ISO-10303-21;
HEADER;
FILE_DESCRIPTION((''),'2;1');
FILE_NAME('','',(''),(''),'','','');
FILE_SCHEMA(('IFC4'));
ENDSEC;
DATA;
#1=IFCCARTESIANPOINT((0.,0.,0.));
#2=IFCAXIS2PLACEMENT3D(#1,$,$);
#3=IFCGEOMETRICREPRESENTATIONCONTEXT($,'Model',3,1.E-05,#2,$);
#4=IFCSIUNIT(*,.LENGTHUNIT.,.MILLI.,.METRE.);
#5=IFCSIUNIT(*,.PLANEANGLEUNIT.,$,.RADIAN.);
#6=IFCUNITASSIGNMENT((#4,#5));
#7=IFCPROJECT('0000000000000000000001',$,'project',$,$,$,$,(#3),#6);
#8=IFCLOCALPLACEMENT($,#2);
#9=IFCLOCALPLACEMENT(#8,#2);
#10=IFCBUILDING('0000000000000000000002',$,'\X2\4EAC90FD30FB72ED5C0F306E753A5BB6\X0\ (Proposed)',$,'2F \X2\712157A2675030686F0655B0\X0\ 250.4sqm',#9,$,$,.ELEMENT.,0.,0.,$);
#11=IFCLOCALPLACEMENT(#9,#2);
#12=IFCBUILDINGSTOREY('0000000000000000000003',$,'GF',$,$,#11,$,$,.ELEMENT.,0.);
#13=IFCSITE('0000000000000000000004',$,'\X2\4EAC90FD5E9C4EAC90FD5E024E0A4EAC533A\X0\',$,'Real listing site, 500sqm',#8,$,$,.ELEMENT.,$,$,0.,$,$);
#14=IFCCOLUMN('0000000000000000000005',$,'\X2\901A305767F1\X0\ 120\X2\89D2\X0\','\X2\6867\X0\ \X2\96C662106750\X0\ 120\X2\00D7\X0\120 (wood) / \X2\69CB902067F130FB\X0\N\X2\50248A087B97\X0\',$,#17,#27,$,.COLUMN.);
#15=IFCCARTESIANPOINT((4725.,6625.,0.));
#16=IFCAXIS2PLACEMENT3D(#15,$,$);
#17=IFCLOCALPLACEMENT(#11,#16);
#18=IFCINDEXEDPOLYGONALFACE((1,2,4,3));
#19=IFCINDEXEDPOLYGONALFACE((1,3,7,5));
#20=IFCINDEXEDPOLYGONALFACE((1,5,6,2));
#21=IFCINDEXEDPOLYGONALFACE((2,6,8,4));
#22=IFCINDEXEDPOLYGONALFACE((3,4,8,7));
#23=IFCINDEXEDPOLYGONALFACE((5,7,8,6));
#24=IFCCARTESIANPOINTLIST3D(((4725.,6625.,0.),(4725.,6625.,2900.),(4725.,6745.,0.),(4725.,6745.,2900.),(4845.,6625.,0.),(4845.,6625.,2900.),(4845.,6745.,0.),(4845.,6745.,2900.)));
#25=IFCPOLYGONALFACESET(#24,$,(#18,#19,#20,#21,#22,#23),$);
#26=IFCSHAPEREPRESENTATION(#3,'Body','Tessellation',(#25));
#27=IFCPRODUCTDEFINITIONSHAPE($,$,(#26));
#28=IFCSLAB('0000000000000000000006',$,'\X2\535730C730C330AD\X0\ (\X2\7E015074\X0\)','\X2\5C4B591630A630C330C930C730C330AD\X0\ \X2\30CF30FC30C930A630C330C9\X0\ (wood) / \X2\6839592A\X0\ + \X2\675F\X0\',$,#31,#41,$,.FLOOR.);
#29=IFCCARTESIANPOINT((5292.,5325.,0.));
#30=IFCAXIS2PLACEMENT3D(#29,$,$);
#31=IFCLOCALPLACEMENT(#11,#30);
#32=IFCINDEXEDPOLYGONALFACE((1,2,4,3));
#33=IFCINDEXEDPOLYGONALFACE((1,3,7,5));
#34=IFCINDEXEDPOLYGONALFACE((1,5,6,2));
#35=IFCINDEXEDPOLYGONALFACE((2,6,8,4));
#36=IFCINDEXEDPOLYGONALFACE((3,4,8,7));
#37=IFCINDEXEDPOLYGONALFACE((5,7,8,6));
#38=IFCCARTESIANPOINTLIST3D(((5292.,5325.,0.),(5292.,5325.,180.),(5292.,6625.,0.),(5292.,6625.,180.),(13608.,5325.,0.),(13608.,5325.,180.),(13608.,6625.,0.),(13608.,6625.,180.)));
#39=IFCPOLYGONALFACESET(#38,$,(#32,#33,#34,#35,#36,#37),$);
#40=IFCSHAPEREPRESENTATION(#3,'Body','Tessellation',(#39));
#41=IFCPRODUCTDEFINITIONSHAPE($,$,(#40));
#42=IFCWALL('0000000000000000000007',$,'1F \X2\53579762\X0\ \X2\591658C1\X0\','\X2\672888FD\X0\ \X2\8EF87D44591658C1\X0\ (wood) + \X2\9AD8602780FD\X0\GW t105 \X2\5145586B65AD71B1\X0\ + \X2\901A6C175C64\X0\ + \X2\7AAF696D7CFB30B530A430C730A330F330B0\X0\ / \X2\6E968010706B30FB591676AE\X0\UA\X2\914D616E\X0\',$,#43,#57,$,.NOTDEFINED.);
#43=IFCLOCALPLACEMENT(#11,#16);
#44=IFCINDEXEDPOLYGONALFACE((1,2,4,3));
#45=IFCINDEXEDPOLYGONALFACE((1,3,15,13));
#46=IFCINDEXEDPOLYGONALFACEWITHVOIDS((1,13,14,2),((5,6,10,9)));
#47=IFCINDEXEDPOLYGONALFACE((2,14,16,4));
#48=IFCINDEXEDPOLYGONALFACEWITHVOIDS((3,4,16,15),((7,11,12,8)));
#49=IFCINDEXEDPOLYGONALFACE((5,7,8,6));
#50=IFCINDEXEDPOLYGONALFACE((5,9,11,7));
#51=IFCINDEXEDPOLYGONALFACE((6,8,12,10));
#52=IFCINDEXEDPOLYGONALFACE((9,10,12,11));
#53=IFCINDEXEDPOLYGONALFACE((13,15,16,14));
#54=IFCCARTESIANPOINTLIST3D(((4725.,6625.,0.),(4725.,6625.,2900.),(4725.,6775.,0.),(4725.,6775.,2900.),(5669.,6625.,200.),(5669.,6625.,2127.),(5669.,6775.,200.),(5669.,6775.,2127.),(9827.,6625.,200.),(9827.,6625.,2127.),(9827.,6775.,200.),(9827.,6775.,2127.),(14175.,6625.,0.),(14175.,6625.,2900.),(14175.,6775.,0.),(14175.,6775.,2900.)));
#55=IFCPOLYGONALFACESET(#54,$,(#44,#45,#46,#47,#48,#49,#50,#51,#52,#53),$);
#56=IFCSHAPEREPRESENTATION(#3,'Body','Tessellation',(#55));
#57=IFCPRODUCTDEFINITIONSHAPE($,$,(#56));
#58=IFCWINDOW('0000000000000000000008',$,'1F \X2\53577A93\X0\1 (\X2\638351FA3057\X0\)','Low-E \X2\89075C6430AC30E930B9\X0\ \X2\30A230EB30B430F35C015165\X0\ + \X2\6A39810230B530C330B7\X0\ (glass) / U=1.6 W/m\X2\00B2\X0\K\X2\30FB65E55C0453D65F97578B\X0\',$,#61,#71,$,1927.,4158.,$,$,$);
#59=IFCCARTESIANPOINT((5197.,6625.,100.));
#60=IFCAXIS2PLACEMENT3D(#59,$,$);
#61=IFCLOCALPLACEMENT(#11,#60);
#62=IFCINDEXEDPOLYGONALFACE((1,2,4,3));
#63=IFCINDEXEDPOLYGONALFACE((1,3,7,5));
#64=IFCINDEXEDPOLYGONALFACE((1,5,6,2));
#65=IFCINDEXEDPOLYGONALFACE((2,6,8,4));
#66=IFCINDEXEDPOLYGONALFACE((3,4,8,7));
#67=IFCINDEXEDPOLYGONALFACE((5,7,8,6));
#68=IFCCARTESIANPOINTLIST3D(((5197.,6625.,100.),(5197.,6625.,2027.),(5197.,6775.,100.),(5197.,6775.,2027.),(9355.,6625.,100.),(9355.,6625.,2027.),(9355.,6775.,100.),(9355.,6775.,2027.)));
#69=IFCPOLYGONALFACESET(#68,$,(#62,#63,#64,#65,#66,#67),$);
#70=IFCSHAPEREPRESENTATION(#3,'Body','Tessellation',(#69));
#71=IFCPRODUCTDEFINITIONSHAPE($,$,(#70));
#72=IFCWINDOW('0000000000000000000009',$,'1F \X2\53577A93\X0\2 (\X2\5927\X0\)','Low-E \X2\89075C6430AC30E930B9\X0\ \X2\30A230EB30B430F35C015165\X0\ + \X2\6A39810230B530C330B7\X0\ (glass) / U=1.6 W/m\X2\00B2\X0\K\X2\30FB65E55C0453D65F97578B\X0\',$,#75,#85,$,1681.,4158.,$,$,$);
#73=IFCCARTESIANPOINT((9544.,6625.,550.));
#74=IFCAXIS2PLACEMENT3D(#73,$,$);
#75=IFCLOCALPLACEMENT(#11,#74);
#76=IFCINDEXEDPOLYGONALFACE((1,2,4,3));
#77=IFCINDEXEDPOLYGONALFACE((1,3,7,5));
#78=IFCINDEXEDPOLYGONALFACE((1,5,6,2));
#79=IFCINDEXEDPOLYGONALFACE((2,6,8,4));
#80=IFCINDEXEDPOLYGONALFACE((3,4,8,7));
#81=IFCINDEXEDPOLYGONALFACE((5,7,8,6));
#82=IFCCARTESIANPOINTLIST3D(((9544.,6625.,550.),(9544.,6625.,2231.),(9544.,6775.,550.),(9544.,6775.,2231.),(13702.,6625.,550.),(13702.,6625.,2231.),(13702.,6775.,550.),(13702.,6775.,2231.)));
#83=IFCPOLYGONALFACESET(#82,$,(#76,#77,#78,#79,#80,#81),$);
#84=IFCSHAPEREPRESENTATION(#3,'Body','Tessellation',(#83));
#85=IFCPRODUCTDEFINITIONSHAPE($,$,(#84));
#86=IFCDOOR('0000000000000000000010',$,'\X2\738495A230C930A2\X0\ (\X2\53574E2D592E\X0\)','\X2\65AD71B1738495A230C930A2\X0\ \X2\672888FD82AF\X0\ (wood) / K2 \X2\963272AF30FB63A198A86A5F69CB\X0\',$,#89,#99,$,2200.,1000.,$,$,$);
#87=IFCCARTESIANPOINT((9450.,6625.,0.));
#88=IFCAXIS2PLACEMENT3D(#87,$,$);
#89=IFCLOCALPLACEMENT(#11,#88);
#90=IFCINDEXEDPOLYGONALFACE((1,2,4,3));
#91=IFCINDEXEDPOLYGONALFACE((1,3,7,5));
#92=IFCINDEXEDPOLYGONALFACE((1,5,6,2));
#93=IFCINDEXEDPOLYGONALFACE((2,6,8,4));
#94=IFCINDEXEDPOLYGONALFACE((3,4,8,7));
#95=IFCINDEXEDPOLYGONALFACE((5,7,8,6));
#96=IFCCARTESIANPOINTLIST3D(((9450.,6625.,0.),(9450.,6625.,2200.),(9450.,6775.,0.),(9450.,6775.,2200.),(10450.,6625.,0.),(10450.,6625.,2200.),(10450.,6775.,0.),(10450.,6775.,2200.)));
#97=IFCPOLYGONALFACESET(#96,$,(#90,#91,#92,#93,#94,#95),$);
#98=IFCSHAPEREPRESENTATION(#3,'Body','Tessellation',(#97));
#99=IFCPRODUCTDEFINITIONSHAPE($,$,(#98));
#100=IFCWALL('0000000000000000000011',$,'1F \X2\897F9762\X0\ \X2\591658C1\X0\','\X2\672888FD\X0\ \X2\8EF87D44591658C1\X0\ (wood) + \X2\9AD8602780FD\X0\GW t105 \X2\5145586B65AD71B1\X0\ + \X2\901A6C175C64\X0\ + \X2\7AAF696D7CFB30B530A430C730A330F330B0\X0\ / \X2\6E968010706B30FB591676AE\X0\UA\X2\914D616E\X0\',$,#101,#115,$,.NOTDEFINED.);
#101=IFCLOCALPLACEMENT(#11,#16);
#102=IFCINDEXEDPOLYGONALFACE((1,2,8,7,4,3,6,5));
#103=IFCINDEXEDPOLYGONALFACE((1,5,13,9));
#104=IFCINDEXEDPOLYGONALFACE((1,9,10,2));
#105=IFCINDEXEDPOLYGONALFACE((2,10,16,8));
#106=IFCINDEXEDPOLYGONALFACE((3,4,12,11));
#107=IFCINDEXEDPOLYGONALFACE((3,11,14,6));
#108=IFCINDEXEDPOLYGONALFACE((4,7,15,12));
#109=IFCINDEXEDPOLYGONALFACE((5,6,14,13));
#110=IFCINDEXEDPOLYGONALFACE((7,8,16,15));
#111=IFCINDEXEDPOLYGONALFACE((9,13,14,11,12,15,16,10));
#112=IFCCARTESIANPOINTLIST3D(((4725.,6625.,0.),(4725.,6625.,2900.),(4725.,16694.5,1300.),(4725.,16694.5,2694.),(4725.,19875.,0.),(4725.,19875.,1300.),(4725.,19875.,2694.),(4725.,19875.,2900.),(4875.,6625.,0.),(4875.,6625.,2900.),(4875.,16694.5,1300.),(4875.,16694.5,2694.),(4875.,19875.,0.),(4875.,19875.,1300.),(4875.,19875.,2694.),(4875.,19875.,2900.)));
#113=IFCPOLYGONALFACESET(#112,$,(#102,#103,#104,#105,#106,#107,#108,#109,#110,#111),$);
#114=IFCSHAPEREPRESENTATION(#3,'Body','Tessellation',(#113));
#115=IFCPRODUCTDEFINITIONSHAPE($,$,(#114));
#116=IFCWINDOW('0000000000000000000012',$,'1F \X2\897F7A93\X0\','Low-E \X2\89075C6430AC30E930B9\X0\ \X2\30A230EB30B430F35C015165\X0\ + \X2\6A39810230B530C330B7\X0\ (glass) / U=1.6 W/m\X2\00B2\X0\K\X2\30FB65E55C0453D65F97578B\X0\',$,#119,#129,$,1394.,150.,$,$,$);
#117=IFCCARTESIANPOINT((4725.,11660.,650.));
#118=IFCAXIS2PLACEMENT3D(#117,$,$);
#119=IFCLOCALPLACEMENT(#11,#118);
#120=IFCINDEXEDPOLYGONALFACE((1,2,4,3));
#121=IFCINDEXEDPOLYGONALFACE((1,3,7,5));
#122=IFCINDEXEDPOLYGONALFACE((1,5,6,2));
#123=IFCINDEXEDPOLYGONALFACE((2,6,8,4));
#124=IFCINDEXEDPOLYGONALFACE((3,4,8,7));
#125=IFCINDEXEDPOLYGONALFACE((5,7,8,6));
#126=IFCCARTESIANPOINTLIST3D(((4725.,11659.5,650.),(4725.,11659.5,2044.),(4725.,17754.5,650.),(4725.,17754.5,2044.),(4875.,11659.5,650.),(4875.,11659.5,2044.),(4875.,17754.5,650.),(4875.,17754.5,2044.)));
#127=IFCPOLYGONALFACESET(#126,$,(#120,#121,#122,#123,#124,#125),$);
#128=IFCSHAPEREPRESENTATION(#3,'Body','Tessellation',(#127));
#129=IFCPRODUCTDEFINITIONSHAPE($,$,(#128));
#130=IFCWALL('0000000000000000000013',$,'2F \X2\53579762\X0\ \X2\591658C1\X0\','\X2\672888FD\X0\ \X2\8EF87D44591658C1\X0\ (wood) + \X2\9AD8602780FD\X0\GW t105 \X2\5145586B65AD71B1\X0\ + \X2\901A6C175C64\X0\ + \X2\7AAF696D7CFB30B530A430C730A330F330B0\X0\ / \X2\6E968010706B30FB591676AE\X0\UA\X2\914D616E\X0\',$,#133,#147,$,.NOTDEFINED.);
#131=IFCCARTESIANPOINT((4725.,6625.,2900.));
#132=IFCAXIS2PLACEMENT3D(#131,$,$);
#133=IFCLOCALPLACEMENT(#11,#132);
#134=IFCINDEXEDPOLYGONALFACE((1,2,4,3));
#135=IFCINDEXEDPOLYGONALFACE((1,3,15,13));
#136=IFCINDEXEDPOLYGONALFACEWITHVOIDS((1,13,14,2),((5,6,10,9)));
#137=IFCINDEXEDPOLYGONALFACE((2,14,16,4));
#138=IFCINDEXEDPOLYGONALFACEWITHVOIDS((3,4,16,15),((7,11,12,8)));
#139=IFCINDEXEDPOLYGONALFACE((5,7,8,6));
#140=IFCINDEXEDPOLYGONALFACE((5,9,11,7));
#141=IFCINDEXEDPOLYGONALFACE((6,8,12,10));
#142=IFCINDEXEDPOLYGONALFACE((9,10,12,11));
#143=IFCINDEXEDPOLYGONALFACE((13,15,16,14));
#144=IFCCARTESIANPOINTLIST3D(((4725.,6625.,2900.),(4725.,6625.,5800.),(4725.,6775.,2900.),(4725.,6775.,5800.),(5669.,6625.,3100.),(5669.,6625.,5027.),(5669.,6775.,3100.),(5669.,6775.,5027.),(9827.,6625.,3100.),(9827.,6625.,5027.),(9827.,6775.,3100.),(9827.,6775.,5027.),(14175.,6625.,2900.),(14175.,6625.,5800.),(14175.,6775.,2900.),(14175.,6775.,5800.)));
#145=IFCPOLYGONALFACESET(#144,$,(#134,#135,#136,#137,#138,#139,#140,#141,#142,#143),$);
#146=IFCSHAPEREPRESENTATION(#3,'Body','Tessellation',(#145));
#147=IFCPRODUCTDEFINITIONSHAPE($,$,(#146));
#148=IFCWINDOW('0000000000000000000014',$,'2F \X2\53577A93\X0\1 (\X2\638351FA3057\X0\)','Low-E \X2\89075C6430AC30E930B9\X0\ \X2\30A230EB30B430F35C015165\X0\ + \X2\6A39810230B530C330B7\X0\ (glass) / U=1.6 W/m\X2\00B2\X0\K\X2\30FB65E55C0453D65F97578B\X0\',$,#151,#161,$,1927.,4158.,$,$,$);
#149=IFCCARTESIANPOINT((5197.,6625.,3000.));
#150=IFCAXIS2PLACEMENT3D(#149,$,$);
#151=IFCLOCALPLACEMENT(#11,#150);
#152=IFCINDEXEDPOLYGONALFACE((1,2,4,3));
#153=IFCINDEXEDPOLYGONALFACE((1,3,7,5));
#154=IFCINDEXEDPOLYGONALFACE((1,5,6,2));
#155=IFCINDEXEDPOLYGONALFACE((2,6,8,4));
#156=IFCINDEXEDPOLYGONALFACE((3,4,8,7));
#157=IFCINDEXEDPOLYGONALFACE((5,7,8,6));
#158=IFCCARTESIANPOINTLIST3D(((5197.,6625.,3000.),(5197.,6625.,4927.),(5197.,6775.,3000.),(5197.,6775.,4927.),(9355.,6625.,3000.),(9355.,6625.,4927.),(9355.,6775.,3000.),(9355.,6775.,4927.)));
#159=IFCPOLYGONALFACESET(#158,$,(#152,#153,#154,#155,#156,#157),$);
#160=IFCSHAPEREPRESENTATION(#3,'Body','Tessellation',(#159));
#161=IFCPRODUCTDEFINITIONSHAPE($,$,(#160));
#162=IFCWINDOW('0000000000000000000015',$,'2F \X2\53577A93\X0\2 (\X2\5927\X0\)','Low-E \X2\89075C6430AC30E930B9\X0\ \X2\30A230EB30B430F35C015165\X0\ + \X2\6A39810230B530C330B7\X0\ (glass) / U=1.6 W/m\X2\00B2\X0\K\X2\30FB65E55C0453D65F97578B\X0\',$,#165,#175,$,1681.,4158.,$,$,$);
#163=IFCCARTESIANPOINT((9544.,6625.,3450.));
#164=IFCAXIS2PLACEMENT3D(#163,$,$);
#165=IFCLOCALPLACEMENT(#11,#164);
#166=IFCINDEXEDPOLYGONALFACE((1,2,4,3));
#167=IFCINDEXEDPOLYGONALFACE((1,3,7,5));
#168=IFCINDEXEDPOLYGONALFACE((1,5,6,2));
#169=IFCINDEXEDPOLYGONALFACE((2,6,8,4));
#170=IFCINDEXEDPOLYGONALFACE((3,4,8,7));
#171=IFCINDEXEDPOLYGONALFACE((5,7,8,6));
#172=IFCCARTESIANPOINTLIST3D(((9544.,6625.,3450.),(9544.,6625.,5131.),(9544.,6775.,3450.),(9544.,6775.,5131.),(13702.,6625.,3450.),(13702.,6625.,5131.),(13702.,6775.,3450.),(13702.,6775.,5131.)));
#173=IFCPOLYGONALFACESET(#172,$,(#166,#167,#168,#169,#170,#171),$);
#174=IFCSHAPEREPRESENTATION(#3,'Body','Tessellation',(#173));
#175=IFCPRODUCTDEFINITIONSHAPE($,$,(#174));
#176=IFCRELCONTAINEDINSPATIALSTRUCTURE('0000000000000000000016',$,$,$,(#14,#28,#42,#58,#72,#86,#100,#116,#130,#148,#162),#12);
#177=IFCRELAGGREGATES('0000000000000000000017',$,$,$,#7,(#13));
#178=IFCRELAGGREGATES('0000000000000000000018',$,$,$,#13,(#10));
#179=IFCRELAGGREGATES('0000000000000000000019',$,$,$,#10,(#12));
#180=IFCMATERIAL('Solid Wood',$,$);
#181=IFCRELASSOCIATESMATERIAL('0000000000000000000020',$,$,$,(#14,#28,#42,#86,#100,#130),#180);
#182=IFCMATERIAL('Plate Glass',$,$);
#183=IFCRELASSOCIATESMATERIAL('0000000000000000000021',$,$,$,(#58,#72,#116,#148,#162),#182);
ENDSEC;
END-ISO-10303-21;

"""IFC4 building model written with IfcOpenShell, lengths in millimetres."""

from ifc_helpers import new_model, si_unit, frame, frame_2d, origin, place, context, project, spatial, rectangle, extrude, material, element, fill, save


model = new_model("IFC4")

# Units and contexts
model_context = context("Model", 3, precision=1e-05, world=origin())
ifc_project = project(units=[si_unit("LENGTHUNIT", "METRE", prefix="MILLI"), si_unit("PLANEANGLEUNIT", "RADIAN")], contexts=[model_context])

# Site, building, storey
site_placement = place(None, origin())
site = spatial("IfcSite", under=ifc_project, at=site_placement, Name="京都府京都市上京区", ObjectType="Real listing site, 500sqm", CompositionType="ELEMENT", RefElevation=0.0)
building_placement = place(site_placement, origin())
building = spatial("IfcBuilding", under=site, at=building_placement, Name="京都・狭小の町家 (Proposed)", ObjectType="2F 無垢材と漆喰 250.4sqm", CompositionType="ELEMENT", ElevationOfRefHeight=0.0, ElevationOfTerrain=0.0)
storey_placement = place(building_placement, origin())
storey = spatial("IfcBuildingStorey", under=building, at=storey_placement, Name="GF", CompositionType="ELEMENT", Elevation=0.0)

# Column
ifc_material_1 = material(Name="Solid Wood")
column_placement = place(storey_placement, frame((4725.0, 6625.0, 0.0)))
element("IfcColumn", 1, at=column_placement, inside=storey, material=ifc_material_1, Name="通し柱 120角", Description="桧 集成材 120×120 (wood) / 構造柱・N値計算", PredefinedType="COLUMN", context=model_context, shape_type="SweptSolid", body=[
    extrude(rectangle(XDim=120.0, YDim=120.0, at=frame_2d((60.0, 60.0))), frame((4725.0, 6625.0, 0.0)), (0.0, 0.0, 1.0), 2900.0),
])

# Slab
slab_1_placement = place(storey_placement, frame((5292.0, 5325.0, 0.0)))
element("IfcSlab", 2, at=slab_1_placement, inside=storey, material=ifc_material_1, Name="南デッキ (縁側)", Description="屋外ウッドデッキ ハードウッド (wood) / 根太 + 束", PredefinedType="FLOOR", context=model_context, shape_type="SweptSolid", body=[
    extrude(rectangle(XDim=8316.0, YDim=1300.0, at=frame_2d((4158.0, 650.0))), frame((5292.0, 5325.0, 0.0)), (0.0, 0.0, 1.0), 180.0),
])

# Wall, openings, windows, door
wall_1_placement = place(storey_placement, frame((4725.0, 6625.0, 0.0)))
wall_1 = element("IfcWall", 3, at=wall_1_placement, inside=storey, material=ifc_material_1, Name="1F 南面 外壁", Description="木製 軸組外壁 (wood) + 高性能GW t105 充填断熱 + 通気層 + 窯業系サイディング / 準耐火・外皮UA配慮", PredefinedType="NOTDEFINED", context=model_context, shape_type="SweptSolid", body=[
    extrude(rectangle(XDim=9450.0, YDim=150.0, at=frame_2d((4725.0, 75.0))), frame((4725.0, 6625.0, 0.0)), (0.0, 0.0, 1.0), 2900.0),
])
opening_1_placement = place(storey_placement, frame((5197.0, 6625.0, 100.0)))
opening_1 = element("IfcOpeningElement", 4, at=opening_1_placement, cuts=wall_1, PredefinedType="NOTDEFINED", context=model_context, shape_type="SweptSolid", body=[
    extrude(rectangle(XDim=4158.0, YDim=150.0, at=frame_2d((2079.0, 75.0))), frame((5197.0, 6625.0, 100.0)), (0.0, 0.0, 1.0), 1927.0),
])
opening_2_placement = place(storey_placement, frame((9544.0, 6625.0, 550.0)))
opening_2 = element("IfcOpeningElement", 5, at=opening_2_placement, cuts=wall_1, PredefinedType="NOTDEFINED", context=model_context, shape_type="SweptSolid", body=[
    extrude(rectangle(XDim=4158.0, YDim=150.0, at=frame_2d((2079.0, 75.0))), frame((9544.0, 6625.0, 550.0)), (0.0, 0.0, 1.0), 1681.0),
])
opening_3_placement = place(storey_placement, frame((9450.0, 6625.0, 0.0)))
opening_3 = element("IfcOpeningElement", 6, at=opening_3_placement, cuts=wall_1, PredefinedType="NOTDEFINED", context=model_context, shape_type="SweptSolid", body=[
    extrude(rectangle(XDim=1000.0, YDim=150.0, at=frame_2d((500.0, 75.0))), frame((9450.0, 6625.0, 0.0)), (0.0, 0.0, 1.0), 2200.0),
])
ifc_material_2 = material(Name="Plate Glass")
window_1_placement = place(storey_placement, frame((5197.0, 6625.0, 100.0)))
window_1 = element("IfcWindow", 7, at=window_1_placement, inside=storey, material=ifc_material_2, Name="1F 南窓1 (掃出し)", Description="Low-E 複層ガラス アルゴン封入 + 樹脂サッシ (glass) / U=1.6 W/m²K・日射取得型", OverallHeight=1927.0, OverallWidth=4158.0, context=model_context, shape_type="SweptSolid", body=[
    extrude(rectangle(XDim=4158.0, YDim=150.0, at=frame_2d((2079.0, 75.0))), frame((5197.0, 6625.0, 100.0)), (0.0, 0.0, 1.0), 1927.0),
])
fill(opening_1, window_1)
window_2_placement = place(storey_placement, frame((9544.0, 6625.0, 550.0)))
window_2 = element("IfcWindow", 8, at=window_2_placement, inside=storey, material=ifc_material_2, Name="1F 南窓2 (大)", Description="Low-E 複層ガラス アルゴン封入 + 樹脂サッシ (glass) / U=1.6 W/m²K・日射取得型", OverallHeight=1681.0, OverallWidth=4158.0, context=model_context, shape_type="SweptSolid", body=[
    extrude(rectangle(XDim=4158.0, YDim=150.0, at=frame_2d((2079.0, 75.0))), frame((9544.0, 6625.0, 550.0)), (0.0, 0.0, 1.0), 1681.0),
])
fill(opening_2, window_2)
door_placement = place(storey_placement, frame((9450.0, 6625.0, 0.0)))
door = element("IfcDoor", 9, at=door_placement, inside=storey, material=ifc_material_1, Name="玄関ドア (南中央)", Description="断熱玄関ドア 木製芯 (wood) / K2 防犯・採風機構", OverallHeight=2200.0, OverallWidth=1000.0, context=model_context, shape_type="SweptSolid", body=[
    extrude(rectangle(XDim=1000.0, YDim=150.0, at=frame_2d((500.0, 75.0))), frame((9450.0, 6625.0, 0.0)), (0.0, 0.0, 1.0), 2200.0),
])
fill(opening_3, door)

# Wall, opening, window
wall_2_placement = place(storey_placement, frame((4725.0, 6625.0, 0.0)))
wall_2 = element("IfcWall", 10, at=wall_2_placement, inside=storey, material=ifc_material_1, Name="1F 西面 外壁", Description="木製 軸組外壁 (wood) + 高性能GW t105 充填断熱 + 通気層 + 窯業系サイディング / 準耐火・外皮UA配慮", PredefinedType="NOTDEFINED", context=model_context, shape_type="SweptSolid", body=[
    extrude(rectangle(XDim=150.0, YDim=13250.0, at=frame_2d((75.0, 6625.0))), frame((4725.0, 6625.0, 0.0)), (0.0, 0.0, 1.0), 2900.0),
])
opening_4_placement = place(storey_placement, frame((4725.0, 11660.0, 650.0)))
opening_4 = element("IfcOpeningElement", 11, at=opening_4_placement, cuts=wall_2, PredefinedType="NOTDEFINED", context=model_context, shape_type="SweptSolid", body=[
    extrude(rectangle(XDim=150.0, YDim=6095.0, at=frame_2d((75.0, 3047.0))), frame((4725.0, 11660.0, 650.0)), (0.0, 0.0, 1.0), 1394.0),
])
window_3_placement = place(storey_placement, frame((4725.0, 11660.0, 650.0)))
window_3 = element("IfcWindow", 12, at=window_3_placement, inside=storey, material=ifc_material_2, Name="1F 西窓", Description="Low-E 複層ガラス アルゴン封入 + 樹脂サッシ (glass) / U=1.6 W/m²K・日射取得型", OverallHeight=1394.0, OverallWidth=150.0, context=model_context, shape_type="SweptSolid", body=[
    extrude(rectangle(XDim=150.0, YDim=6095.0, at=frame_2d((75.0, 3047.0))), frame((4725.0, 11660.0, 650.0)), (0.0, 0.0, 1.0), 1394.0),
])
fill(opening_4, window_3)

# Wall, openings, windows
wall_3_placement = place(storey_placement, frame((4725.0, 6625.0, 2900.0)))
wall_3 = element("IfcWall", 13, at=wall_3_placement, inside=storey, material=ifc_material_1, Name="2F 南面 外壁", Description="木製 軸組外壁 (wood) + 高性能GW t105 充填断熱 + 通気層 + 窯業系サイディング / 準耐火・外皮UA配慮", PredefinedType="NOTDEFINED", context=model_context, shape_type="SweptSolid", body=[
    extrude(rectangle(XDim=9450.0, YDim=150.0, at=frame_2d((4725.0, 75.0))), frame((4725.0, 6625.0, 2900.0)), (0.0, 0.0, 1.0), 2900.0),
])
opening_5_placement = place(storey_placement, frame((5197.0, 6625.0, 3000.0)))
opening_5 = element("IfcOpeningElement", 14, at=opening_5_placement, cuts=wall_3, PredefinedType="NOTDEFINED", context=model_context, shape_type="SweptSolid", body=[
    extrude(rectangle(XDim=4158.0, YDim=150.0, at=frame_2d((2079.0, 75.0))), frame((5197.0, 6625.0, 3000.0)), (0.0, 0.0, 1.0), 1927.0),
])
opening_6_placement = place(storey_placement, frame((9544.0, 6625.0, 3450.0)))
opening_6 = element("IfcOpeningElement", 15, at=opening_6_placement, cuts=wall_3, PredefinedType="NOTDEFINED", context=model_context, shape_type="SweptSolid", body=[
    extrude(rectangle(XDim=4158.0, YDim=150.0, at=frame_2d((2079.0, 75.0))), frame((9544.0, 6625.0, 3450.0)), (0.0, 0.0, 1.0), 1681.0),
])
window_4_placement = place(storey_placement, frame((5197.0, 6625.0, 3000.0)))
window_4 = element("IfcWindow", 16, at=window_4_placement, inside=storey, material=ifc_material_2, Name="2F 南窓1 (掃出し)", Description="Low-E 複層ガラス アルゴン封入 + 樹脂サッシ (glass) / U=1.6 W/m²K・日射取得型", OverallHeight=1927.0, OverallWidth=4158.0, context=model_context, shape_type="SweptSolid", body=[
    extrude(rectangle(XDim=4158.0, YDim=150.0, at=frame_2d((2079.0, 75.0))), frame((5197.0, 6625.0, 3000.0)), (0.0, 0.0, 1.0), 1927.0),
])
fill(opening_5, window_4)
window_5_placement = place(storey_placement, frame((9544.0, 6625.0, 3450.0)))
window_5 = element("IfcWindow", 17, at=window_5_placement, inside=storey, material=ifc_material_2, Name="2F 南窓2 (大)", Description="Low-E 複層ガラス アルゴン封入 + 樹脂サッシ (glass) / U=1.6 W/m²K・日射取得型", OverallHeight=1681.0, OverallWidth=4158.0, context=model_context, shape_type="SweptSolid", body=[
    extrude(rectangle(XDim=4158.0, YDim=150.0, at=frame_2d((2079.0, 75.0))), frame((9544.0, 6625.0, 3450.0)), (0.0, 0.0, 1.0), 1681.0),
])
fill(opening_6, window_5)

save(model, "model.ifc")
